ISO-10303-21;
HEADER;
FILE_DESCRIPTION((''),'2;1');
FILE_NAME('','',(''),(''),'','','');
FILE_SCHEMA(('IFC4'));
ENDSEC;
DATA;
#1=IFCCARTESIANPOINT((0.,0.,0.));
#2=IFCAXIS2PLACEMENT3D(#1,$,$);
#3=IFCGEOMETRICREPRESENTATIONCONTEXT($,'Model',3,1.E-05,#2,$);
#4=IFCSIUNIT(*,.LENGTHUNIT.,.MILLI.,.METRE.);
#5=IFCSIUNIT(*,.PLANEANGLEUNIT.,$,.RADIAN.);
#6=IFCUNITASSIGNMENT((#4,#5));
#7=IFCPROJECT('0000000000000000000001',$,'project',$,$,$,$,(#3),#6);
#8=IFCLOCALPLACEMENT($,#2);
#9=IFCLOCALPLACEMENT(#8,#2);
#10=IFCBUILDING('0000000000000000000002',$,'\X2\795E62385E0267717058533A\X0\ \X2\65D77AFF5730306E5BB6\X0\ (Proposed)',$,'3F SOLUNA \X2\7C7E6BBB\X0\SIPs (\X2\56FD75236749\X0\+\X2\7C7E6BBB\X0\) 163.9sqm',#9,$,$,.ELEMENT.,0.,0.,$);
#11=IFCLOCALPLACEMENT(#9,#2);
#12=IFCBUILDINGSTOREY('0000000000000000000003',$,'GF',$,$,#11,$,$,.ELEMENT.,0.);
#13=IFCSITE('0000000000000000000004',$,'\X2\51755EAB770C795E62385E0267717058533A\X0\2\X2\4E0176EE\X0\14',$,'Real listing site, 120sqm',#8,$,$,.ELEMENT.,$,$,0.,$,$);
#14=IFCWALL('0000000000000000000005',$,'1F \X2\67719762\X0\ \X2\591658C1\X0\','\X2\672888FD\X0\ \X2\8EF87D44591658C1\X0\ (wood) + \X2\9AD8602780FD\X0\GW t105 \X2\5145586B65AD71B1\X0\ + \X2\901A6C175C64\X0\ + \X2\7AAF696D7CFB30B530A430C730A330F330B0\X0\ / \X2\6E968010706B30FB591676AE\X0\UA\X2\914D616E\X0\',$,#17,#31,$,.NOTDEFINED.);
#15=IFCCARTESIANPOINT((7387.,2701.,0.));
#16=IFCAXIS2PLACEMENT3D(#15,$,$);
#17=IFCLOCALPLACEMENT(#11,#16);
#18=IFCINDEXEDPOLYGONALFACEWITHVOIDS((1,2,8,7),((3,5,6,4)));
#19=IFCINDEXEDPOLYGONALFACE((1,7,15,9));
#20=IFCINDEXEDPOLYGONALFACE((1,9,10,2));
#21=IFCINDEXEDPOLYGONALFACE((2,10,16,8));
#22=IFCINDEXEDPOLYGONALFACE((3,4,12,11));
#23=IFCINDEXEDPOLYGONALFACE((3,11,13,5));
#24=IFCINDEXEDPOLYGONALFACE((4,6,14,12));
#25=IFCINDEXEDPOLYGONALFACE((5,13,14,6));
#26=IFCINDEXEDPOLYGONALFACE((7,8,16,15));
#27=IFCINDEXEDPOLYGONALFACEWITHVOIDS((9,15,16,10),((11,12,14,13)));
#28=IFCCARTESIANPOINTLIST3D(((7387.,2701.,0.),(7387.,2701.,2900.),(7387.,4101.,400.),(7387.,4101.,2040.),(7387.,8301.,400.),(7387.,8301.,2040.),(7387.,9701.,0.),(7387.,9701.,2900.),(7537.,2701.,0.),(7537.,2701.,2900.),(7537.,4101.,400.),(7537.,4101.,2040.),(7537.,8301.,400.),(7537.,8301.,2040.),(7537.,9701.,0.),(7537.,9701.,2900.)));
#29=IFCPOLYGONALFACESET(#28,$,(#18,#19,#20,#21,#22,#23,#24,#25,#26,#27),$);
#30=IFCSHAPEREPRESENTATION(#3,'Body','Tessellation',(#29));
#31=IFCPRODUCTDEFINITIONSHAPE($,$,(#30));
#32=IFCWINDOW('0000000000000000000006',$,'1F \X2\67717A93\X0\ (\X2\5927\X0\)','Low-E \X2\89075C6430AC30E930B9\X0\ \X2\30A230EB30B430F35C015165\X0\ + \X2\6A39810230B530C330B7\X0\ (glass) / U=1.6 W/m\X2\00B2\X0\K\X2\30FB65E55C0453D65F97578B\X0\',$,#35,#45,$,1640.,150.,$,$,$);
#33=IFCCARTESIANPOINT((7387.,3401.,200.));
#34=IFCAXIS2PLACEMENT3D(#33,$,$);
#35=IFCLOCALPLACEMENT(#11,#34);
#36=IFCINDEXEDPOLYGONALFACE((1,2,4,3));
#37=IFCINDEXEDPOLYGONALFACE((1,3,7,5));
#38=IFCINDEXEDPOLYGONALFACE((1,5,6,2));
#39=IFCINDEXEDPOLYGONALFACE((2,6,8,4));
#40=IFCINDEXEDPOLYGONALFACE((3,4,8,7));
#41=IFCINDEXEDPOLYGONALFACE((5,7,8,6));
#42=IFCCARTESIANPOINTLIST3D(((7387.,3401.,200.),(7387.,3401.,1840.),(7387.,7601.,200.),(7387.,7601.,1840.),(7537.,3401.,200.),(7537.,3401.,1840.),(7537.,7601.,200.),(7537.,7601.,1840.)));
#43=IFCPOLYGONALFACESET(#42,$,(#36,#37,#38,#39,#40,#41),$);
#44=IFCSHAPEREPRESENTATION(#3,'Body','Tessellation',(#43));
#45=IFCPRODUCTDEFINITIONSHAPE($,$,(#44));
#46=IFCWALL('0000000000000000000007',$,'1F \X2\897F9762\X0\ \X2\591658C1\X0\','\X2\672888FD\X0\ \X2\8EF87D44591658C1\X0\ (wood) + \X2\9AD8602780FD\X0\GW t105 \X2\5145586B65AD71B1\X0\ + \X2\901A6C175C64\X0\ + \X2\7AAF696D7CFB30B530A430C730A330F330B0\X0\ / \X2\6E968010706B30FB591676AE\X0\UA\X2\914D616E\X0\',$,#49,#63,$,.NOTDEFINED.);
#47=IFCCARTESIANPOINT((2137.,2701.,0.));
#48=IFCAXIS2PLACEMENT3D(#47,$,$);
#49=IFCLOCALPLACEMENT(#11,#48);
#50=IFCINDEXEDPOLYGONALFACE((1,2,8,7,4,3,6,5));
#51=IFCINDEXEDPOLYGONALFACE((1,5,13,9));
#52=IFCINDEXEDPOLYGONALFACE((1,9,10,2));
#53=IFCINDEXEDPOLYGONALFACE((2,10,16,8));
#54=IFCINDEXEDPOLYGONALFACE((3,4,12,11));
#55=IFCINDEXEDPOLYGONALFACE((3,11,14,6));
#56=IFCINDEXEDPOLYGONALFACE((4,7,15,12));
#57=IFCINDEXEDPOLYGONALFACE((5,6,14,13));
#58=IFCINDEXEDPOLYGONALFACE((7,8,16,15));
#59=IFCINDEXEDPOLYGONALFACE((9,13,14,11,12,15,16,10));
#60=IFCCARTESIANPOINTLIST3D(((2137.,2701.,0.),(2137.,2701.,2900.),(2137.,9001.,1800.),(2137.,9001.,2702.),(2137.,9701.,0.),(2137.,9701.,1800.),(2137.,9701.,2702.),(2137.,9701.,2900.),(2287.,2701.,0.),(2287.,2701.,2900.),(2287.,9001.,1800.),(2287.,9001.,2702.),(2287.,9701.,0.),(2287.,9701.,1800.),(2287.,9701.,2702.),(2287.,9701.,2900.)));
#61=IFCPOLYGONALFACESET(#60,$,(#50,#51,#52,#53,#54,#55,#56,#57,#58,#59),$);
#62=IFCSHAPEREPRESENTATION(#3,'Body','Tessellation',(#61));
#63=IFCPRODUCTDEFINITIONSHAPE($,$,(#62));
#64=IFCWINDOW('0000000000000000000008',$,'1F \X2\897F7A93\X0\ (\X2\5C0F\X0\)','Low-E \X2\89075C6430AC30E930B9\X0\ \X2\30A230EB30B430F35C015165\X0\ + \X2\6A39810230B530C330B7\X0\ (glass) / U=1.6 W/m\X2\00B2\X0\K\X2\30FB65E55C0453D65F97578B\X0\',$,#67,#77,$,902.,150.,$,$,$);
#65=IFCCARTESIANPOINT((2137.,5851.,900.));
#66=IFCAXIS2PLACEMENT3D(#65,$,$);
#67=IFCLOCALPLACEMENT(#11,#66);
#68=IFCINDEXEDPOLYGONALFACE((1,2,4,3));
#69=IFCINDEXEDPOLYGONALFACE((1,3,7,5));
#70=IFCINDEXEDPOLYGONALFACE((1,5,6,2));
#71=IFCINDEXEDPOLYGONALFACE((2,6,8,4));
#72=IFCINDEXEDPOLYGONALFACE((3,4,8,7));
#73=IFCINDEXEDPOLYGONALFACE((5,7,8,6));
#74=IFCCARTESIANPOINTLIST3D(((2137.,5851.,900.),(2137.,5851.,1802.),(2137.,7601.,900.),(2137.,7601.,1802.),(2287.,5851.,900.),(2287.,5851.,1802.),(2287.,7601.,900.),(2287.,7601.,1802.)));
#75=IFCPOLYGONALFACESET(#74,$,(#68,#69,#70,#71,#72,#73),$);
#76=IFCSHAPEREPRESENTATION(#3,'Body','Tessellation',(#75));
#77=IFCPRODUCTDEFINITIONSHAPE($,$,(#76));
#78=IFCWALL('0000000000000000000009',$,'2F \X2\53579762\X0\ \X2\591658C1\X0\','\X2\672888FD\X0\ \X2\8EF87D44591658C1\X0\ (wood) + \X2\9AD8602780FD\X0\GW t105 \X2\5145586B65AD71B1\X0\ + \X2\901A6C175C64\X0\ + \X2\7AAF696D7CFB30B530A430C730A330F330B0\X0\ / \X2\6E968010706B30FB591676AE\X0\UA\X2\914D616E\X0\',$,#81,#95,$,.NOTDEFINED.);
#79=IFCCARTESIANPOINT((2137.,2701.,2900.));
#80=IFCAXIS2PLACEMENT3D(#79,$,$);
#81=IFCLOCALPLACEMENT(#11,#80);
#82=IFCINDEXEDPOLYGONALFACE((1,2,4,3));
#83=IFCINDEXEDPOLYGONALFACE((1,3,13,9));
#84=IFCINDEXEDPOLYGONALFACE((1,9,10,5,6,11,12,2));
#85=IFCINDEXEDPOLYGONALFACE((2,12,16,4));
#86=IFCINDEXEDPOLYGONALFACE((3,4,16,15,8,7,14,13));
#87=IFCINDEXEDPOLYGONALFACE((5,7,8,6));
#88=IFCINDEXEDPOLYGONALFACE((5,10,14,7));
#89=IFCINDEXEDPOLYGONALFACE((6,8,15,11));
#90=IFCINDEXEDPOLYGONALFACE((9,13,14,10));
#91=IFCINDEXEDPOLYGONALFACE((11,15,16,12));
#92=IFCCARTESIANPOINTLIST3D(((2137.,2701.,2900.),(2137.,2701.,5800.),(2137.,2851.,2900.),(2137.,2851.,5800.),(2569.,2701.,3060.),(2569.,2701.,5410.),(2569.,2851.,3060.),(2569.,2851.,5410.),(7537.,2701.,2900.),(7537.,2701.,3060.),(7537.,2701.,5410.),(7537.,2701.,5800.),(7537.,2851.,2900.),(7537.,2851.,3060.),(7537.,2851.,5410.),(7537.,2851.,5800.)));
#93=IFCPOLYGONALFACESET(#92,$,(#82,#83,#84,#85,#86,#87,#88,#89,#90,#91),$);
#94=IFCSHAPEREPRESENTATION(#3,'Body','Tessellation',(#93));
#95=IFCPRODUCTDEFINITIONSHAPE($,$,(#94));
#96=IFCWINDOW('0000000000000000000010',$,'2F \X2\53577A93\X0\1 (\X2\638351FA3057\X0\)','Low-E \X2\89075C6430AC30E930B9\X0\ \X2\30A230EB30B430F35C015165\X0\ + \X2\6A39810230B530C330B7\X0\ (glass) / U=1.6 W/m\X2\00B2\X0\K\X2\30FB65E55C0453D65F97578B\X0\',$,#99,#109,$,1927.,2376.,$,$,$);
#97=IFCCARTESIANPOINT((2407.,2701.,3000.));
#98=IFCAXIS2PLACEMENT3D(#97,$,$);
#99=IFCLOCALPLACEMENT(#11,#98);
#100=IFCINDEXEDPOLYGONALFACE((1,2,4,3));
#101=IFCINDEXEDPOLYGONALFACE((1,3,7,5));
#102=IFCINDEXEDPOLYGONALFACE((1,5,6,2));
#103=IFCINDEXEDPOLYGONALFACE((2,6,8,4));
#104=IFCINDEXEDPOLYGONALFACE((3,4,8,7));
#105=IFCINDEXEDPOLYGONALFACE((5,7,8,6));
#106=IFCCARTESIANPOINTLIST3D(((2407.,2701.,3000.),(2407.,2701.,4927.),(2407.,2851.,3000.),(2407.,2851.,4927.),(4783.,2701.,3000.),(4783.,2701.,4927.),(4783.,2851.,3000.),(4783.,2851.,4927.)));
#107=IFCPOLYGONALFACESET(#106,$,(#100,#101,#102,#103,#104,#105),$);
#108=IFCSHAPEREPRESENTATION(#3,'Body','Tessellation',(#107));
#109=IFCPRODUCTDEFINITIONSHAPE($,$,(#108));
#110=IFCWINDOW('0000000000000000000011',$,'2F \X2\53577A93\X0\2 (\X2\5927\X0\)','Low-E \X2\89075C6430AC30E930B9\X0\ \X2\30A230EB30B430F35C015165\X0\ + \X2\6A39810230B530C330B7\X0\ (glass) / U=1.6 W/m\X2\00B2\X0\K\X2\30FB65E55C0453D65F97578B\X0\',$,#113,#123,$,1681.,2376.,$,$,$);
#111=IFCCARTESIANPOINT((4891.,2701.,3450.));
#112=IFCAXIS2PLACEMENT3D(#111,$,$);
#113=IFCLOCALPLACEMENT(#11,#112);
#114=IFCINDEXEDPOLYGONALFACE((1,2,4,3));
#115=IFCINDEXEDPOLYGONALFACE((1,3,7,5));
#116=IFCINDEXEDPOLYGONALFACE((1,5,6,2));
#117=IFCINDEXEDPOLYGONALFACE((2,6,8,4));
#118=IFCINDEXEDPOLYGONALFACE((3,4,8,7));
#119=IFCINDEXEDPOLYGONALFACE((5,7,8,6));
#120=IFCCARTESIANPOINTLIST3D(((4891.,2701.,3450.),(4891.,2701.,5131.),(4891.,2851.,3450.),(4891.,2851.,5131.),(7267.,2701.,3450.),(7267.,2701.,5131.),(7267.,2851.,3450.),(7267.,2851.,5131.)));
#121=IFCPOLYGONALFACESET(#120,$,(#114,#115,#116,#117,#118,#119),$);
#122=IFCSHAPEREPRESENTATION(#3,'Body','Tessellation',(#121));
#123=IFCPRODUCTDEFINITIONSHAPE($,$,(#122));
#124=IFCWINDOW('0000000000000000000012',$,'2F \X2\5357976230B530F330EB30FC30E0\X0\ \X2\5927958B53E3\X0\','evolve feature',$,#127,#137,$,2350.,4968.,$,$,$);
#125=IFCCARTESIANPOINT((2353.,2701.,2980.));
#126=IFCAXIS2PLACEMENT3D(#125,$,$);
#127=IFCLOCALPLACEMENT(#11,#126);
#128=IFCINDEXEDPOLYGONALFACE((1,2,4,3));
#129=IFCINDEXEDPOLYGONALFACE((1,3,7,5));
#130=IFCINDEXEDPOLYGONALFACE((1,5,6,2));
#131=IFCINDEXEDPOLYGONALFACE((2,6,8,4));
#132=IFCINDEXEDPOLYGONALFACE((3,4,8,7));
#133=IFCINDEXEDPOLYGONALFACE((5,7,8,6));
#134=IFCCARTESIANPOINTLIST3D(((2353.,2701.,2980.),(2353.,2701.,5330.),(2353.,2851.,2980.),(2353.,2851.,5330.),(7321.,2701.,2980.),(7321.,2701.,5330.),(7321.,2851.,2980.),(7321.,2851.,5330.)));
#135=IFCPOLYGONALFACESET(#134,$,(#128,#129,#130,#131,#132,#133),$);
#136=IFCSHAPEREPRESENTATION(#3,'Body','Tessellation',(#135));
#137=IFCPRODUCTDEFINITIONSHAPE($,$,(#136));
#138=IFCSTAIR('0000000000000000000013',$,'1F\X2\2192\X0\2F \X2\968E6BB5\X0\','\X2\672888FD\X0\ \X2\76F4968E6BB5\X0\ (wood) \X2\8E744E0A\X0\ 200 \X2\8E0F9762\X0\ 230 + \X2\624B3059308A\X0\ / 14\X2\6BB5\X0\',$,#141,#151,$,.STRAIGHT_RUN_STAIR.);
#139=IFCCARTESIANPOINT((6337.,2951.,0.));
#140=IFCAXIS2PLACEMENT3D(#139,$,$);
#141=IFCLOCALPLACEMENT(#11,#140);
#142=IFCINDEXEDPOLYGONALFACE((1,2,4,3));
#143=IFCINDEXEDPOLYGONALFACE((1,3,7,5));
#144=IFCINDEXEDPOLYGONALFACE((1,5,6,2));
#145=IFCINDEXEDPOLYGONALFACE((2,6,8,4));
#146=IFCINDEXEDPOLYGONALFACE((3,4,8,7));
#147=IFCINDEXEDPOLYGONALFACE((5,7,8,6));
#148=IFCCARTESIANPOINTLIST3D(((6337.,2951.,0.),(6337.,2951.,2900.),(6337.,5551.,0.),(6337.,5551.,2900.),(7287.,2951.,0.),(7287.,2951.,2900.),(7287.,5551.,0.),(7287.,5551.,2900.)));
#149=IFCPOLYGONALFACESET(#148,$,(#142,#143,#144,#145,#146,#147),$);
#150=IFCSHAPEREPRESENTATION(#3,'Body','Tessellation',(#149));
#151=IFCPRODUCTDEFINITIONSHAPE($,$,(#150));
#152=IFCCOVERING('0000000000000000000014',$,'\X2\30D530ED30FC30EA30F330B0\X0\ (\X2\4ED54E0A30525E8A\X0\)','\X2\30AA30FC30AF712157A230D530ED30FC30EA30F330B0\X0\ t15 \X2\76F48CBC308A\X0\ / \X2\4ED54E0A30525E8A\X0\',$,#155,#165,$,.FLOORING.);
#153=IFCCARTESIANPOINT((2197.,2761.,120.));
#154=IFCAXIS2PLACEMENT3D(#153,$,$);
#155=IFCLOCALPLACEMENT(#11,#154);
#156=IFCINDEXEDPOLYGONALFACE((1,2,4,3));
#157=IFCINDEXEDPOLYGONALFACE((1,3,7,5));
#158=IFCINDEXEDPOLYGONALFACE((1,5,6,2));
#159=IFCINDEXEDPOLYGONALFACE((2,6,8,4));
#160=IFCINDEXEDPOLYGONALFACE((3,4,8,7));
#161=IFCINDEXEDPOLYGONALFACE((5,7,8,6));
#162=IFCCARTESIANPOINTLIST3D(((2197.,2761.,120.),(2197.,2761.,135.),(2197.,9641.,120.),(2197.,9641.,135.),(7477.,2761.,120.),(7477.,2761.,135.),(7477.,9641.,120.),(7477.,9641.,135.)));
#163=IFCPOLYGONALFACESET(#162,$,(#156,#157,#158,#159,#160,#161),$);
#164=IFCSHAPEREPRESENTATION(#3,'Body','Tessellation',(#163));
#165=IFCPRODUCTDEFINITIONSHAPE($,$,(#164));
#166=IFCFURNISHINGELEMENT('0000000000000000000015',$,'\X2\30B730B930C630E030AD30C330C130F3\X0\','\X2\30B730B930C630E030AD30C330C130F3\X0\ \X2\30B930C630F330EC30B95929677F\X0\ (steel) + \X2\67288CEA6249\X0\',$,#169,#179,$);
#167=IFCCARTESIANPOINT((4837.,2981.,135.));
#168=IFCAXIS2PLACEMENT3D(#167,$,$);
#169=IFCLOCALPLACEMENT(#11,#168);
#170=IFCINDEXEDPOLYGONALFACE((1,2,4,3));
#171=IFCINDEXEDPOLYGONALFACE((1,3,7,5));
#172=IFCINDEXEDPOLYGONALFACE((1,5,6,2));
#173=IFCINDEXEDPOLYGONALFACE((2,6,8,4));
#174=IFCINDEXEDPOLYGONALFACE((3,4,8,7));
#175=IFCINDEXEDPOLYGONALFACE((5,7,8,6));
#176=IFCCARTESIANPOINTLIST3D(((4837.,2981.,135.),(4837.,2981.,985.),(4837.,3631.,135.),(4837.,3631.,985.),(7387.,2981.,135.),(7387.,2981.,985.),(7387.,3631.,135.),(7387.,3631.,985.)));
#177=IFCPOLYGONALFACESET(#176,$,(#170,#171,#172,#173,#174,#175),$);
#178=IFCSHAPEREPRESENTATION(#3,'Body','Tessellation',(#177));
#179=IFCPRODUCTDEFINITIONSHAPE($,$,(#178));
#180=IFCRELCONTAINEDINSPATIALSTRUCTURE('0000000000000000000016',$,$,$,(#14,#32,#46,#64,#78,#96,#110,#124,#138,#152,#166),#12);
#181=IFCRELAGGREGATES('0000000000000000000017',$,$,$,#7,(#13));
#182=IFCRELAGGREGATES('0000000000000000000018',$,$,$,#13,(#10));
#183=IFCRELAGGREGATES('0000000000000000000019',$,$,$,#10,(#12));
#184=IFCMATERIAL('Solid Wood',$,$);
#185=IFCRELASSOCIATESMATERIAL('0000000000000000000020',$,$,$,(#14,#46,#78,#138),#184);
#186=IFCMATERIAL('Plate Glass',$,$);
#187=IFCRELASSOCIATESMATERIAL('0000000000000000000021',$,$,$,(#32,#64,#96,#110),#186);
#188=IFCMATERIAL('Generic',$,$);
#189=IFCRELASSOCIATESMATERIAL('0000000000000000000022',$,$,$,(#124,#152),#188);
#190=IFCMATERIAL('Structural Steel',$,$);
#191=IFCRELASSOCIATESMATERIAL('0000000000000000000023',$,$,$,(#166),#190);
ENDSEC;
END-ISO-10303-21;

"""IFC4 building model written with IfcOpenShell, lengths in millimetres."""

from ifc_helpers import new_model, si_unit, frame, frame_2d, origin, place, context, project, spatial, rectangle, extrude, material, element, fill, save


model = new_model("IFC4")

# Units and contexts
model_context = context("Model", 3, precision=1e-05, world=origin())
ifc_project = project(units=[si_unit("LENGTHUNIT", "METRE", prefix="MILLI"), si_unit("PLANEANGLEUNIT", "RADIAN")], contexts=[model_context])

# Site, building, storey
site_placement = place(None, origin())
site = spatial("IfcSite", under=ifc_project, at=site_placement, Name="兵庫県神戸市東灘区2丁目14", ObjectType="Real listing site, 120sqm", CompositionType="ELEMENT", RefElevation=0.0)
building_placement = place(site_placement, origin())
building = spatial("IfcBuilding", under=site, at=building_placement, Name="神戸市東灘区 旗竿地の家 (Proposed)", ObjectType="3F SOLUNA 籾殻SIPs (国産杉+籾殻) 163.9sqm", CompositionType="ELEMENT", ElevationOfRefHeight=0.0, ElevationOfTerrain=0.0)
storey_placement = place(building_placement, origin())
storey = spatial("IfcBuildingStorey", under=building, at=storey_placement, Name="GF", CompositionType="ELEMENT", Elevation=0.0)

# Shared definitions
ifc_material_1 = material(Name="Solid Wood")
ifc_material_2 = material(Name="Generic")

# Shared definitions
ifc_material_3 = material(Name="Plate Glass")

# Walls, openings, windows
wall_1_placement = place(storey_placement, frame((7387.0, 2701.0, 0.0)))
wall_1 = element("IfcWall", 1, at=wall_1_placement, inside=storey, material=ifc_material_1, Name="1F 東面 外壁", Description="木製 軸組外壁 (wood) + 高性能GW t105 充填断熱 + 通気層 + 窯業系サイディング / 準耐火・外皮UA配慮", PredefinedType="NOTDEFINED", context=model_context, shape_type="SweptSolid", body=[
    extrude(rectangle(XDim=150.0, YDim=7000.0, at=frame_2d((75.0, 3500.0))), frame((7387.0, 2701.0, 0.0)), (0.0, 0.0, 1.0), 2900.0),
])
opening_1_placement = place(storey_placement, frame((7387.0, 3401.0, 200.0)))
opening_1 = element("IfcOpeningElement", 2, at=opening_1_placement, cuts=wall_1, PredefinedType="NOTDEFINED", context=model_context, shape_type="SweptSolid", body=[
    extrude(rectangle(XDim=150.0, YDim=4200.0, at=frame_2d((75.0, 2100.0))), frame((7387.0, 3401.0, 200.0)), (0.0, 0.0, 1.0), 1640.0),
])
window_1_placement = place(storey_placement, frame((7387.0, 3401.0, 200.0)))
window_1 = element("IfcWindow", 3, at=window_1_placement, inside=storey, material=ifc_material_3, Name="1F 東窓 (大)", Description="Low-E 複層ガラス アルゴン封入 + 樹脂サッシ (glass) / U=1.6 W/m²K・日射取得型", OverallHeight=1640.0, OverallWidth=150.0, context=model_context, shape_type="SweptSolid", body=[
    extrude(rectangle(XDim=150.0, YDim=4200.0, at=frame_2d((75.0, 2100.0))), frame((7387.0, 3401.0, 200.0)), (0.0, 0.0, 1.0), 1640.0),
])
fill(opening_1, window_1)
wall_2_placement = place(storey_placement, frame((2137.0, 2701.0, 0.0)))
wall_2 = element("IfcWall", 4, at=wall_2_placement, inside=storey, material=ifc_material_1, Name="1F 西面 外壁", Description="木製 軸組外壁 (wood) + 高性能GW t105 充填断熱 + 通気層 + 窯業系サイディング / 準耐火・外皮UA配慮", PredefinedType="NOTDEFINED", context=model_context, shape_type="SweptSolid", body=[
    extrude(rectangle(XDim=150.0, YDim=7000.0, at=frame_2d((75.0, 3500.0))), frame((2137.0, 2701.0, 0.0)), (0.0, 0.0, 1.0), 2900.0),
])
opening_2_placement = place(storey_placement, frame((2137.0, 5851.0, 900.0)))
opening_2 = element("IfcOpeningElement", 5, at=opening_2_placement, cuts=wall_2, PredefinedType="NOTDEFINED", context=model_context, shape_type="SweptSolid", body=[
    extrude(rectangle(XDim=150.0, YDim=1750.0, at=frame_2d((75.0, 875.0))), frame((2137.0, 5851.0, 900.0)), (0.0, 0.0, 1.0), 902.0),
])
window_2_placement = place(storey_placement, frame((2137.0, 5851.0, 900.0)))
window_2 = element("IfcWindow", 6, at=window_2_placement, inside=storey, material=ifc_material_3, Name="1F 西窓 (小)", Description="Low-E 複層ガラス アルゴン封入 + 樹脂サッシ (glass) / U=1.6 W/m²K・日射取得型", OverallHeight=902.0, OverallWidth=150.0, context=model_context, shape_type="SweptSolid", body=[
    extrude(rectangle(XDim=150.0, YDim=1750.0, at=frame_2d((75.0, 875.0))), frame((2137.0, 5851.0, 900.0)), (0.0, 0.0, 1.0), 902.0),
])
fill(opening_2, window_2)

# Wall, openings, windows
wall_3_placement = place(storey_placement, frame((2137.0, 2701.0, 2900.0)))
wall_3 = element("IfcWall", 7, at=wall_3_placement, inside=storey, material=ifc_material_1, Name="2F 南面 外壁", Description="木製 軸組外壁 (wood) + 高性能GW t105 充填断熱 + 通気層 + 窯業系サイディング / 準耐火・外皮UA配慮", PredefinedType="NOTDEFINED", context=model_context, shape_type="SweptSolid", body=[
    extrude(rectangle(XDim=5400.0, YDim=150.0, at=frame_2d((2700.0, 75.0))), frame((2137.0, 2701.0, 2900.0)), (0.0, 0.0, 1.0), 2900.0),
])
opening_3_placement = place(storey_placement, frame((2407.0, 2701.0, 3000.0)))
opening_3 = element("IfcOpeningElement", 8, at=opening_3_placement, cuts=wall_3, PredefinedType="NOTDEFINED", context=model_context, shape_type="SweptSolid", body=[
    extrude(rectangle(XDim=2376.0, YDim=150.0, at=frame_2d((1188.0, 75.0))), frame((2407.0, 2701.0, 3000.0)), (0.0, 0.0, 1.0), 1927.0),
])
opening_4_placement = place(storey_placement, frame((4891.0, 2701.0, 3450.0)))
opening_4 = element("IfcOpeningElement", 9, at=opening_4_placement, cuts=wall_3, PredefinedType="NOTDEFINED", context=model_context, shape_type="SweptSolid", body=[
    extrude(rectangle(XDim=2376.0, YDim=150.0, at=frame_2d((1188.0, 75.0))), frame((4891.0, 2701.0, 3450.0)), (0.0, 0.0, 1.0), 1681.0),
])
opening_5_placement = place(storey_placement, frame((2353.0, 2701.0, 2980.0)))
opening_5 = element("IfcOpeningElement", 10, at=opening_5_placement, cuts=wall_3, PredefinedType="NOTDEFINED", context=model_context, shape_type="SweptSolid", body=[
    extrude(rectangle(XDim=4968.0, YDim=150.0, at=frame_2d((2484.0, 75.0))), frame((2353.0, 2701.0, 2980.0)), (0.0, 0.0, 1.0), 2350.0),
])
window_3_placement = place(storey_placement, frame((2407.0, 2701.0, 3000.0)))
window_3 = element("IfcWindow", 11, at=window_3_placement, inside=storey, material=ifc_material_3, Name="2F 南窓1 (掃出し)", Description="Low-E 複層ガラス アルゴン封入 + 樹脂サッシ (glass) / U=1.6 W/m²K・日射取得型", OverallHeight=1927.0, OverallWidth=2376.0, context=model_context, shape_type="SweptSolid", body=[
    extrude(rectangle(XDim=2376.0, YDim=150.0, at=frame_2d((1188.0, 75.0))), frame((2407.0, 2701.0, 3000.0)), (0.0, 0.0, 1.0), 1927.0),
])
fill(opening_3, window_3)
window_4_placement = place(storey_placement, frame((4891.0, 2701.0, 3450.0)))
window_4 = element("IfcWindow", 12, at=window_4_placement, inside=storey, material=ifc_material_3, Name="2F 南窓2 (大)", Description="Low-E 複層ガラス アルゴン封入 + 樹脂サッシ (glass) / U=1.6 W/m²K・日射取得型", OverallHeight=1681.0, OverallWidth=2376.0, context=model_context, shape_type="SweptSolid", body=[
    extrude(rectangle(XDim=2376.0, YDim=150.0, at=frame_2d((1188.0, 75.0))), frame((4891.0, 2701.0, 3450.0)), (0.0, 0.0, 1.0), 1681.0),
])
fill(opening_4, window_4)
window_5_placement = place(storey_placement, frame((2353.0, 2701.0, 2980.0)))
window_5 = element("IfcWindow", 13, at=window_5_placement, inside=storey, material=ifc_material_2, Name="2F 南面サンルーム 大開口", Description="evolve feature", OverallHeight=2350.0, OverallWidth=4968.0, context=model_context, shape_type="SweptSolid", body=[
    extrude(rectangle(XDim=4968.0, YDim=150.0, at=frame_2d((2484.0, 75.0))), frame((2353.0, 2701.0, 2980.0)), (0.0, 0.0, 1.0), 2350.0),
])
fill(opening_5, window_5)

# Stair
stair_placement = place(storey_placement, frame((6337.0, 2951.0, 0.0)))
element("IfcStair", 14, at=stair_placement, inside=storey, material=ifc_material_1, Name="1F→2F 階段", Description="木製 直階段 (wood) 蹴上 200 踏面 230 + 手すり / 14段", PredefinedType="STRAIGHT_RUN_STAIR", context=model_context, shape_type="SweptSolid", body=[
    extrude(rectangle(XDim=950.0, YDim=2600.0, at=frame_2d((475.0, 1300.0))), frame((6337.0, 2951.0, 0.0)), (0.0, 0.0, 1.0), 2900.0),
])

# Covering
covering_placement = place(storey_placement, frame((2197.0, 2761.0, 120.0)))
element("IfcCovering", 15, at=covering_placement, inside=storey, material=ifc_material_2, Name="フローリング (仕上げ床)", Description="オーク無垢フローリング t15 直貼り / 仕上げ床", PredefinedType="FLOORING", context=model_context, shape_type="SweptSolid", body=[
    extrude(rectangle(XDim=5280.0, YDim=6880.0, at=frame_2d((2640.0, 3440.0))), frame((2197.0, 2761.0, 120.0)), (0.0, 0.0, 1.0), 15.0),
])

# Furnishing element
ifc_material_4 = material(Name="Structural Steel")
furnishing_placement = place(storey_placement, frame((4837.0, 2981.0, 135.0)))
element("IfcFurnishingElement", 16, at=furnishing_placement, inside=storey, material=ifc_material_4, Name="システムキッチン", Description="システムキッチン ステンレス天板 (steel) + 木質扉", context=model_context, shape_type="SweptSolid", body=[
    extrude(rectangle(XDim=2550.0, YDim=650.0, at=frame_2d((1275.0, 325.0))), frame((4837.0, 2981.0, 135.0)), (0.0, 0.0, 1.0), 850.0),
])

save(model, "model.ifc")
